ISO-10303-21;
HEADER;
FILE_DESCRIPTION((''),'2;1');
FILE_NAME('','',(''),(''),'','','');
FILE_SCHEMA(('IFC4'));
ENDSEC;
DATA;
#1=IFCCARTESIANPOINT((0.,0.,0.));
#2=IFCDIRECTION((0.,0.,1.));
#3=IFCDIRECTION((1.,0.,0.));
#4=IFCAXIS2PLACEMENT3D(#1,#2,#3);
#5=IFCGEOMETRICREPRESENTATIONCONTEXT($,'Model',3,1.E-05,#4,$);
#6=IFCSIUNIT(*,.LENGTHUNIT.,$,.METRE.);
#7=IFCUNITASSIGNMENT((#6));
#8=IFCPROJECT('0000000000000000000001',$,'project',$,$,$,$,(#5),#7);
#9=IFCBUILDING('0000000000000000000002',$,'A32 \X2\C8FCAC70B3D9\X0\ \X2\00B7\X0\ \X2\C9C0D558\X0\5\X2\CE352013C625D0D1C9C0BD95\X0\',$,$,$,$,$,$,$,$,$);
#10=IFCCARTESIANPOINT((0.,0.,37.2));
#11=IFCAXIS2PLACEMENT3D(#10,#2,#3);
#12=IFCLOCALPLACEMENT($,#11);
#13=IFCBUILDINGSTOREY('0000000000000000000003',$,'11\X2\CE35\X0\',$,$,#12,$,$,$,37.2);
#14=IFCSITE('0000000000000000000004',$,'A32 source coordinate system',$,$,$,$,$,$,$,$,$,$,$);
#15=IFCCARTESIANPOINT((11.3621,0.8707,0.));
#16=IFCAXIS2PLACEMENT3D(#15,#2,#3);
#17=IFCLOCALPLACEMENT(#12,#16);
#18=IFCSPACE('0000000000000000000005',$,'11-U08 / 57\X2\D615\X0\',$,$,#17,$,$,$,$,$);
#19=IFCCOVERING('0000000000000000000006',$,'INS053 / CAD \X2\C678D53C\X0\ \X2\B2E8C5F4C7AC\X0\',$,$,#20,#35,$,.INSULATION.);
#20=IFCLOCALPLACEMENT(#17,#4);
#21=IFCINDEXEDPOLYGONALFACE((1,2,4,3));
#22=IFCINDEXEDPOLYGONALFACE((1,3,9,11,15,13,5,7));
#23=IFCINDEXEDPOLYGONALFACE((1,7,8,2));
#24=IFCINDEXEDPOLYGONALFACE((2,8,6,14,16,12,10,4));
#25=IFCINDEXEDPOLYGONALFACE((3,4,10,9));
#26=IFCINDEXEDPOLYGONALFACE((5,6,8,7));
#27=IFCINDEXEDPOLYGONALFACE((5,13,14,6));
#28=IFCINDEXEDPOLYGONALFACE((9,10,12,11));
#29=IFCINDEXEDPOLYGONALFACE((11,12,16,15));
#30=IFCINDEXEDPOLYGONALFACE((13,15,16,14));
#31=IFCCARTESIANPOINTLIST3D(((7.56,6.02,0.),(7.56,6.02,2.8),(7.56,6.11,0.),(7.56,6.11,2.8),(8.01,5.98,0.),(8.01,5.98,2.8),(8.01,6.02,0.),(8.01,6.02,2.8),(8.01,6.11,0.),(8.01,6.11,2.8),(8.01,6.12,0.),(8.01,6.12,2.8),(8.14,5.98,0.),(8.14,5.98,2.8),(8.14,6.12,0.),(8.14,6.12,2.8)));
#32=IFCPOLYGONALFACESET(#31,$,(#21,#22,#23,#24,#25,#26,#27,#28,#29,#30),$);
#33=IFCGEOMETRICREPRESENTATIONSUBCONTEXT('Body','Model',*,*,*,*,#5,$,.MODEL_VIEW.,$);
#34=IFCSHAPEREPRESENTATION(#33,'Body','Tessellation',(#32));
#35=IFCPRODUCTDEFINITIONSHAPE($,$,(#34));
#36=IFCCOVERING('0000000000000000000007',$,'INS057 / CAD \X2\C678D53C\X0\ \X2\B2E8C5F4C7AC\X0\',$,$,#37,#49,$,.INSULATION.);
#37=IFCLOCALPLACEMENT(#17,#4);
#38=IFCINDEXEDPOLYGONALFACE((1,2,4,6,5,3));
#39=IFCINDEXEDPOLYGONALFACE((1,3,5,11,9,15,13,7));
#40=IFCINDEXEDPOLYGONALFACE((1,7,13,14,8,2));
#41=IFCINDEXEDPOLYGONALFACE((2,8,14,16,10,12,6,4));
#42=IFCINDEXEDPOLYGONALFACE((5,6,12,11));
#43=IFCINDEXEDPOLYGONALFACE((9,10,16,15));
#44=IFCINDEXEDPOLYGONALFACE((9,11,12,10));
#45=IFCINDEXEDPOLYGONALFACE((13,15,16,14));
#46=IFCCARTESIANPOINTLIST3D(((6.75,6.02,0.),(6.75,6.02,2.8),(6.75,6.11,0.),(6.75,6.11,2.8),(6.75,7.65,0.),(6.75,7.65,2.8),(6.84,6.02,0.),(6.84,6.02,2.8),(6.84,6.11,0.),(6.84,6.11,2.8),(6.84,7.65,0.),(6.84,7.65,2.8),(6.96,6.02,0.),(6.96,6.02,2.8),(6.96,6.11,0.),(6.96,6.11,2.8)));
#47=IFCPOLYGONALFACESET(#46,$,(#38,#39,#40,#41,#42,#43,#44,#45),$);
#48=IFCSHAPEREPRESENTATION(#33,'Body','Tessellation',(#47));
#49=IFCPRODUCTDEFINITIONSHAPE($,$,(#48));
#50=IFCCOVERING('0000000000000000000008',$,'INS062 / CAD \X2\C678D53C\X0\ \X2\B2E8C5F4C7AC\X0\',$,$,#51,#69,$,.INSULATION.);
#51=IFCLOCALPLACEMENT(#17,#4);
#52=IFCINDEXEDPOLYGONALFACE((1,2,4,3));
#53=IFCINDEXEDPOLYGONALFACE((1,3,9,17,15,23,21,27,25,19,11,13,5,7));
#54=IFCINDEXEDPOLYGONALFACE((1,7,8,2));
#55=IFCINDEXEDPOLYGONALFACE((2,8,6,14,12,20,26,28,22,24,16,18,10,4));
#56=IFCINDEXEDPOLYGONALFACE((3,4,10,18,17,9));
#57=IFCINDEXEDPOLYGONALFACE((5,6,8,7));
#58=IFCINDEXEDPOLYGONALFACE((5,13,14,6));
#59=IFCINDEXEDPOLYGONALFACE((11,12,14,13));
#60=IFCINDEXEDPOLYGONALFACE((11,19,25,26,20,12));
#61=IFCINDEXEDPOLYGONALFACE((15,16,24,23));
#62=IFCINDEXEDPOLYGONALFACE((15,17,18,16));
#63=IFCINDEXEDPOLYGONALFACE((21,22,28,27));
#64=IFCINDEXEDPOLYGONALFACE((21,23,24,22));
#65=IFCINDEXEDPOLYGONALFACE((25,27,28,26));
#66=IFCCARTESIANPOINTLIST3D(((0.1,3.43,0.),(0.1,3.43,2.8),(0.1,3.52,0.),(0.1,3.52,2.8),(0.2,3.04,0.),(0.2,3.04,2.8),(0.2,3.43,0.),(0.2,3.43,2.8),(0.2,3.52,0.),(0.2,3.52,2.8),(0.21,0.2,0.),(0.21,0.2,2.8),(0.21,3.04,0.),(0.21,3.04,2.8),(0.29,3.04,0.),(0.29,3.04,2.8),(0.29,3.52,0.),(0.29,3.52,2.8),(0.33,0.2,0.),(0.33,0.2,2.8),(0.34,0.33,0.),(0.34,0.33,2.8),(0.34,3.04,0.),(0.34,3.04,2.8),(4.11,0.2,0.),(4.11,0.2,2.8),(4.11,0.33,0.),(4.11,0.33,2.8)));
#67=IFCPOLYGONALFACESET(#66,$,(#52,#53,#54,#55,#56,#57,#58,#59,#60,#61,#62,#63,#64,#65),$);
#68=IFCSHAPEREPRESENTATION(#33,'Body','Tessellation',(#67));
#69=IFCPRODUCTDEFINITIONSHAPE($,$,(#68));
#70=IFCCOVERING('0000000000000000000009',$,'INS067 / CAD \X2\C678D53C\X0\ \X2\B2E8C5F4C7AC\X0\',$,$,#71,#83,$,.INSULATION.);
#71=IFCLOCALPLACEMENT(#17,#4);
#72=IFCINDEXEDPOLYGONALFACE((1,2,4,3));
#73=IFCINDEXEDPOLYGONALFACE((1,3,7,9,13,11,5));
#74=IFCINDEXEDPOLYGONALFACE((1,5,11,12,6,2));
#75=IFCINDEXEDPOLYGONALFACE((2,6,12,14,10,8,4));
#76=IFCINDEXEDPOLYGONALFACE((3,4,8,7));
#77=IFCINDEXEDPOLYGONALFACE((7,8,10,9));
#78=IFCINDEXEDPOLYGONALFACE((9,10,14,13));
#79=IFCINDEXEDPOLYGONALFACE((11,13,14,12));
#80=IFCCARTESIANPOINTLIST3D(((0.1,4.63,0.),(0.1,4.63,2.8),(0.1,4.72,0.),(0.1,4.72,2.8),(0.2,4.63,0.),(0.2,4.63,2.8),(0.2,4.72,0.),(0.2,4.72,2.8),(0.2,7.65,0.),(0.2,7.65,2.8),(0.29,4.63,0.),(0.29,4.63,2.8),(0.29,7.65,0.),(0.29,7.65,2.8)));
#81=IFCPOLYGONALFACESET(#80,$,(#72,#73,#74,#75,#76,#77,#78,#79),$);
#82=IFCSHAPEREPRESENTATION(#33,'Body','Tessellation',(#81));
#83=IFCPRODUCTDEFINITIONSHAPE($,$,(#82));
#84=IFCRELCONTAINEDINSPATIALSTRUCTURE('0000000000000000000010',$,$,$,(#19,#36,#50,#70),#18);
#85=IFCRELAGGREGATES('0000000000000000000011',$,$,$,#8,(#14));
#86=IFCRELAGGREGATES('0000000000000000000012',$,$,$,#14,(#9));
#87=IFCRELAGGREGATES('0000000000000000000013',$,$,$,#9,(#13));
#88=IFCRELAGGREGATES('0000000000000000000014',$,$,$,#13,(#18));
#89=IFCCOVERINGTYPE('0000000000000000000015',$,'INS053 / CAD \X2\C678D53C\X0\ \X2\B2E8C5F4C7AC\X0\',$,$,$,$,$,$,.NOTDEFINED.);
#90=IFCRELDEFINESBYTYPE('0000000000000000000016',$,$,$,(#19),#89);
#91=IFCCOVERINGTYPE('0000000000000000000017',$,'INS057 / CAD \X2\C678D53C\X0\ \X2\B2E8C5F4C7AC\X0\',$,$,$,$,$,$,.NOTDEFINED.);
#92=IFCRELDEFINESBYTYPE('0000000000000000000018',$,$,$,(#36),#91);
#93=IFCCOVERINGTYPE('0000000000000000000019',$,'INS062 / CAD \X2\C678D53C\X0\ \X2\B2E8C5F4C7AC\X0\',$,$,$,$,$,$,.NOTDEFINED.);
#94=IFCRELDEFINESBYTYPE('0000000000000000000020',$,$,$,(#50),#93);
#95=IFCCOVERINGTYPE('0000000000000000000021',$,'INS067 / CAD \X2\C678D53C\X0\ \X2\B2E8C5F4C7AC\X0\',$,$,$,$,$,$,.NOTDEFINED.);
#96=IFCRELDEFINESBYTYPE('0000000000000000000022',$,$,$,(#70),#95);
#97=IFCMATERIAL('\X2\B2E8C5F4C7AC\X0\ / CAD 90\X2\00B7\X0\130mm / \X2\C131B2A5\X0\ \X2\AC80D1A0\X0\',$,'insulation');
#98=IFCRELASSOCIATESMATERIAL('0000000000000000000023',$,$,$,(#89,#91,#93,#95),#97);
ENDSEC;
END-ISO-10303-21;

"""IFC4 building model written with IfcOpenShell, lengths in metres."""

from ifc_helpers import new_model, si_unit, frame, origin, origin_with_axes, place, context, subcontext, project, spatial, polyline, outline, extrude, source, transform, mapped, material, type_object, type_shapes, element, save


model = new_model("IFC4")

# Units and contexts
model_context = context("Model", 3, precision=1e-05, world=origin_with_axes())
body_context = subcontext(model_context, "Body", "Model", "MODEL_VIEW")
ifc_project = project(units=[si_unit("LENGTHUNIT", "METRE")], contexts=[model_context])

# Site, building, storey, space
site = spatial("IfcSite", under=ifc_project, Name="A32 source coordinate system")
building = spatial("IfcBuilding", under=site, Name="A32 주거동 · 지하5층–옥탑지붕")
storey_placement = place(None, frame((0.0, 0.0, 37.2), z_axis=(0.0, 0.0, 1.0), x_axis=(1.0, 0.0, 0.0)))
storey = spatial("IfcBuildingStorey", under=building, at=storey_placement, Name="11층", Elevation=37.2)
space_1_placement = place(storey_placement, frame((11.3621, 0.8707, 0.0), z_axis=(0.0, 0.0, 1.0), x_axis=(1.0, 0.0, 0.0)))
space_1 = spatial("IfcSpace", under=storey, at=space_1_placement, Name="11-U08 / 57형")

# Coverings
ifc_material = material(Name="단열재 / CAD 90·130mm / 성능 검토", Category="insulation")
covering_type_1 = type_object("IfcCoveringType", Name="INS053 / CAD 외피 단열재", PredefinedType="NOTDEFINED", material=ifc_material)
shared_shape_1 = source(origin(), body_context, "Body", "SweptSolid", [
    extrude(outline(polyline([(8.01, 6.12), (8.14, 6.12), (8.14, 5.98), (8.01, 5.98), (8.01, 6.02), (7.56, 6.02), (7.56, 6.11), (8.01, 6.11), (8.01, 6.12)])), origin(), (0.0, 0.0, 1.0), 2.8),
])
type_shapes(covering_type_1, [shared_shape_1])
covering_1_placement = place(space_1_placement, origin_with_axes())
element("IfcCovering", 1, at=covering_1_placement, inside=space_1, type_object=covering_type_1, Name="INS053 / CAD 외피 단열재", PredefinedType="INSULATION", context=body_context, shape_type="MappedRepresentation", body=[
    mapped(shared_shape_1, transform((0.0, 0.0, 0.0), scale=1.0)),
])
covering_type_2 = type_object("IfcCoveringType", Name="INS057 / CAD 외피 단열재", PredefinedType="NOTDEFINED", material=ifc_material)
shared_shape_2 = source(origin(), body_context, "Body", "SweptSolid", [
    extrude(outline(polyline([(6.84, 6.11), (6.96, 6.11), (6.96, 6.02), (6.84, 6.02), (6.75, 6.02), (6.75, 6.11), (6.75, 7.65), (6.84, 7.65), (6.84, 6.11)])), origin(), (0.0, 0.0, 1.0), 2.8),
])
type_shapes(covering_type_2, [shared_shape_2])
covering_2_placement = place(space_1_placement, origin_with_axes())
element("IfcCovering", 2, at=covering_2_placement, inside=space_1, type_object=covering_type_2, Name="INS057 / CAD 외피 단열재", PredefinedType="INSULATION", context=body_context, shape_type="MappedRepresentation", body=[
    mapped(shared_shape_2, transform((0.0, 0.0, 0.0), scale=1.0)),
])
covering_type_3 = type_object("IfcCoveringType", Name="INS062 / CAD 외피 단열재", PredefinedType="NOTDEFINED", material=ifc_material)
shared_shape_3 = source(origin(), body_context, "Body", "SweptSolid", [
    extrude(outline(polyline([(4.11, 0.2), (0.33, 0.2), (0.21, 0.2), (0.21, 3.04), (0.2, 3.04), (0.2, 3.43), (0.1, 3.43), (0.1, 3.52), (0.2, 3.52), (0.29, 3.52), (0.29, 3.04), (0.34, 3.04), (0.34, 0.33), (4.11, 0.33), (4.11, 0.2)])), origin(), (0.0, 0.0, 1.0), 2.8),
])
type_shapes(covering_type_3, [shared_shape_3])
covering_3_placement = place(space_1_placement, origin_with_axes())
element("IfcCovering", 3, at=covering_3_placement, inside=space_1, type_object=covering_type_3, Name="INS062 / CAD 외피 단열재", PredefinedType="INSULATION", context=body_context, shape_type="MappedRepresentation", body=[
    mapped(shared_shape_3, transform((0.0, 0.0, 0.0), scale=1.0)),
])
covering_type_4 = type_object("IfcCoveringType", Name="INS067 / CAD 외피 단열재", PredefinedType="NOTDEFINED", material=ifc_material)
shared_shape_4 = source(origin(), body_context, "Body", "SweptSolid", [
    extrude(outline(polyline([(0.1, 4.72), (0.2, 4.72), (0.2, 7.65), (0.29, 7.65), (0.29, 4.63), (0.2, 4.63), (0.1, 4.63), (0.1, 4.72)])), origin(), (0.0, 0.0, 1.0), 2.8),
])
type_shapes(covering_type_4, [shared_shape_4])
covering_4_placement = place(space_1_placement, origin_with_axes())
element("IfcCovering", 4, at=covering_4_placement, inside=space_1, type_object=covering_type_4, Name="INS067 / CAD 외피 단열재", PredefinedType="INSULATION", context=body_context, shape_type="MappedRepresentation", body=[
    mapped(shared_shape_4, transform((0.0, 0.0, 0.0), scale=1.0)),
])

save(model, "model.ifc")
